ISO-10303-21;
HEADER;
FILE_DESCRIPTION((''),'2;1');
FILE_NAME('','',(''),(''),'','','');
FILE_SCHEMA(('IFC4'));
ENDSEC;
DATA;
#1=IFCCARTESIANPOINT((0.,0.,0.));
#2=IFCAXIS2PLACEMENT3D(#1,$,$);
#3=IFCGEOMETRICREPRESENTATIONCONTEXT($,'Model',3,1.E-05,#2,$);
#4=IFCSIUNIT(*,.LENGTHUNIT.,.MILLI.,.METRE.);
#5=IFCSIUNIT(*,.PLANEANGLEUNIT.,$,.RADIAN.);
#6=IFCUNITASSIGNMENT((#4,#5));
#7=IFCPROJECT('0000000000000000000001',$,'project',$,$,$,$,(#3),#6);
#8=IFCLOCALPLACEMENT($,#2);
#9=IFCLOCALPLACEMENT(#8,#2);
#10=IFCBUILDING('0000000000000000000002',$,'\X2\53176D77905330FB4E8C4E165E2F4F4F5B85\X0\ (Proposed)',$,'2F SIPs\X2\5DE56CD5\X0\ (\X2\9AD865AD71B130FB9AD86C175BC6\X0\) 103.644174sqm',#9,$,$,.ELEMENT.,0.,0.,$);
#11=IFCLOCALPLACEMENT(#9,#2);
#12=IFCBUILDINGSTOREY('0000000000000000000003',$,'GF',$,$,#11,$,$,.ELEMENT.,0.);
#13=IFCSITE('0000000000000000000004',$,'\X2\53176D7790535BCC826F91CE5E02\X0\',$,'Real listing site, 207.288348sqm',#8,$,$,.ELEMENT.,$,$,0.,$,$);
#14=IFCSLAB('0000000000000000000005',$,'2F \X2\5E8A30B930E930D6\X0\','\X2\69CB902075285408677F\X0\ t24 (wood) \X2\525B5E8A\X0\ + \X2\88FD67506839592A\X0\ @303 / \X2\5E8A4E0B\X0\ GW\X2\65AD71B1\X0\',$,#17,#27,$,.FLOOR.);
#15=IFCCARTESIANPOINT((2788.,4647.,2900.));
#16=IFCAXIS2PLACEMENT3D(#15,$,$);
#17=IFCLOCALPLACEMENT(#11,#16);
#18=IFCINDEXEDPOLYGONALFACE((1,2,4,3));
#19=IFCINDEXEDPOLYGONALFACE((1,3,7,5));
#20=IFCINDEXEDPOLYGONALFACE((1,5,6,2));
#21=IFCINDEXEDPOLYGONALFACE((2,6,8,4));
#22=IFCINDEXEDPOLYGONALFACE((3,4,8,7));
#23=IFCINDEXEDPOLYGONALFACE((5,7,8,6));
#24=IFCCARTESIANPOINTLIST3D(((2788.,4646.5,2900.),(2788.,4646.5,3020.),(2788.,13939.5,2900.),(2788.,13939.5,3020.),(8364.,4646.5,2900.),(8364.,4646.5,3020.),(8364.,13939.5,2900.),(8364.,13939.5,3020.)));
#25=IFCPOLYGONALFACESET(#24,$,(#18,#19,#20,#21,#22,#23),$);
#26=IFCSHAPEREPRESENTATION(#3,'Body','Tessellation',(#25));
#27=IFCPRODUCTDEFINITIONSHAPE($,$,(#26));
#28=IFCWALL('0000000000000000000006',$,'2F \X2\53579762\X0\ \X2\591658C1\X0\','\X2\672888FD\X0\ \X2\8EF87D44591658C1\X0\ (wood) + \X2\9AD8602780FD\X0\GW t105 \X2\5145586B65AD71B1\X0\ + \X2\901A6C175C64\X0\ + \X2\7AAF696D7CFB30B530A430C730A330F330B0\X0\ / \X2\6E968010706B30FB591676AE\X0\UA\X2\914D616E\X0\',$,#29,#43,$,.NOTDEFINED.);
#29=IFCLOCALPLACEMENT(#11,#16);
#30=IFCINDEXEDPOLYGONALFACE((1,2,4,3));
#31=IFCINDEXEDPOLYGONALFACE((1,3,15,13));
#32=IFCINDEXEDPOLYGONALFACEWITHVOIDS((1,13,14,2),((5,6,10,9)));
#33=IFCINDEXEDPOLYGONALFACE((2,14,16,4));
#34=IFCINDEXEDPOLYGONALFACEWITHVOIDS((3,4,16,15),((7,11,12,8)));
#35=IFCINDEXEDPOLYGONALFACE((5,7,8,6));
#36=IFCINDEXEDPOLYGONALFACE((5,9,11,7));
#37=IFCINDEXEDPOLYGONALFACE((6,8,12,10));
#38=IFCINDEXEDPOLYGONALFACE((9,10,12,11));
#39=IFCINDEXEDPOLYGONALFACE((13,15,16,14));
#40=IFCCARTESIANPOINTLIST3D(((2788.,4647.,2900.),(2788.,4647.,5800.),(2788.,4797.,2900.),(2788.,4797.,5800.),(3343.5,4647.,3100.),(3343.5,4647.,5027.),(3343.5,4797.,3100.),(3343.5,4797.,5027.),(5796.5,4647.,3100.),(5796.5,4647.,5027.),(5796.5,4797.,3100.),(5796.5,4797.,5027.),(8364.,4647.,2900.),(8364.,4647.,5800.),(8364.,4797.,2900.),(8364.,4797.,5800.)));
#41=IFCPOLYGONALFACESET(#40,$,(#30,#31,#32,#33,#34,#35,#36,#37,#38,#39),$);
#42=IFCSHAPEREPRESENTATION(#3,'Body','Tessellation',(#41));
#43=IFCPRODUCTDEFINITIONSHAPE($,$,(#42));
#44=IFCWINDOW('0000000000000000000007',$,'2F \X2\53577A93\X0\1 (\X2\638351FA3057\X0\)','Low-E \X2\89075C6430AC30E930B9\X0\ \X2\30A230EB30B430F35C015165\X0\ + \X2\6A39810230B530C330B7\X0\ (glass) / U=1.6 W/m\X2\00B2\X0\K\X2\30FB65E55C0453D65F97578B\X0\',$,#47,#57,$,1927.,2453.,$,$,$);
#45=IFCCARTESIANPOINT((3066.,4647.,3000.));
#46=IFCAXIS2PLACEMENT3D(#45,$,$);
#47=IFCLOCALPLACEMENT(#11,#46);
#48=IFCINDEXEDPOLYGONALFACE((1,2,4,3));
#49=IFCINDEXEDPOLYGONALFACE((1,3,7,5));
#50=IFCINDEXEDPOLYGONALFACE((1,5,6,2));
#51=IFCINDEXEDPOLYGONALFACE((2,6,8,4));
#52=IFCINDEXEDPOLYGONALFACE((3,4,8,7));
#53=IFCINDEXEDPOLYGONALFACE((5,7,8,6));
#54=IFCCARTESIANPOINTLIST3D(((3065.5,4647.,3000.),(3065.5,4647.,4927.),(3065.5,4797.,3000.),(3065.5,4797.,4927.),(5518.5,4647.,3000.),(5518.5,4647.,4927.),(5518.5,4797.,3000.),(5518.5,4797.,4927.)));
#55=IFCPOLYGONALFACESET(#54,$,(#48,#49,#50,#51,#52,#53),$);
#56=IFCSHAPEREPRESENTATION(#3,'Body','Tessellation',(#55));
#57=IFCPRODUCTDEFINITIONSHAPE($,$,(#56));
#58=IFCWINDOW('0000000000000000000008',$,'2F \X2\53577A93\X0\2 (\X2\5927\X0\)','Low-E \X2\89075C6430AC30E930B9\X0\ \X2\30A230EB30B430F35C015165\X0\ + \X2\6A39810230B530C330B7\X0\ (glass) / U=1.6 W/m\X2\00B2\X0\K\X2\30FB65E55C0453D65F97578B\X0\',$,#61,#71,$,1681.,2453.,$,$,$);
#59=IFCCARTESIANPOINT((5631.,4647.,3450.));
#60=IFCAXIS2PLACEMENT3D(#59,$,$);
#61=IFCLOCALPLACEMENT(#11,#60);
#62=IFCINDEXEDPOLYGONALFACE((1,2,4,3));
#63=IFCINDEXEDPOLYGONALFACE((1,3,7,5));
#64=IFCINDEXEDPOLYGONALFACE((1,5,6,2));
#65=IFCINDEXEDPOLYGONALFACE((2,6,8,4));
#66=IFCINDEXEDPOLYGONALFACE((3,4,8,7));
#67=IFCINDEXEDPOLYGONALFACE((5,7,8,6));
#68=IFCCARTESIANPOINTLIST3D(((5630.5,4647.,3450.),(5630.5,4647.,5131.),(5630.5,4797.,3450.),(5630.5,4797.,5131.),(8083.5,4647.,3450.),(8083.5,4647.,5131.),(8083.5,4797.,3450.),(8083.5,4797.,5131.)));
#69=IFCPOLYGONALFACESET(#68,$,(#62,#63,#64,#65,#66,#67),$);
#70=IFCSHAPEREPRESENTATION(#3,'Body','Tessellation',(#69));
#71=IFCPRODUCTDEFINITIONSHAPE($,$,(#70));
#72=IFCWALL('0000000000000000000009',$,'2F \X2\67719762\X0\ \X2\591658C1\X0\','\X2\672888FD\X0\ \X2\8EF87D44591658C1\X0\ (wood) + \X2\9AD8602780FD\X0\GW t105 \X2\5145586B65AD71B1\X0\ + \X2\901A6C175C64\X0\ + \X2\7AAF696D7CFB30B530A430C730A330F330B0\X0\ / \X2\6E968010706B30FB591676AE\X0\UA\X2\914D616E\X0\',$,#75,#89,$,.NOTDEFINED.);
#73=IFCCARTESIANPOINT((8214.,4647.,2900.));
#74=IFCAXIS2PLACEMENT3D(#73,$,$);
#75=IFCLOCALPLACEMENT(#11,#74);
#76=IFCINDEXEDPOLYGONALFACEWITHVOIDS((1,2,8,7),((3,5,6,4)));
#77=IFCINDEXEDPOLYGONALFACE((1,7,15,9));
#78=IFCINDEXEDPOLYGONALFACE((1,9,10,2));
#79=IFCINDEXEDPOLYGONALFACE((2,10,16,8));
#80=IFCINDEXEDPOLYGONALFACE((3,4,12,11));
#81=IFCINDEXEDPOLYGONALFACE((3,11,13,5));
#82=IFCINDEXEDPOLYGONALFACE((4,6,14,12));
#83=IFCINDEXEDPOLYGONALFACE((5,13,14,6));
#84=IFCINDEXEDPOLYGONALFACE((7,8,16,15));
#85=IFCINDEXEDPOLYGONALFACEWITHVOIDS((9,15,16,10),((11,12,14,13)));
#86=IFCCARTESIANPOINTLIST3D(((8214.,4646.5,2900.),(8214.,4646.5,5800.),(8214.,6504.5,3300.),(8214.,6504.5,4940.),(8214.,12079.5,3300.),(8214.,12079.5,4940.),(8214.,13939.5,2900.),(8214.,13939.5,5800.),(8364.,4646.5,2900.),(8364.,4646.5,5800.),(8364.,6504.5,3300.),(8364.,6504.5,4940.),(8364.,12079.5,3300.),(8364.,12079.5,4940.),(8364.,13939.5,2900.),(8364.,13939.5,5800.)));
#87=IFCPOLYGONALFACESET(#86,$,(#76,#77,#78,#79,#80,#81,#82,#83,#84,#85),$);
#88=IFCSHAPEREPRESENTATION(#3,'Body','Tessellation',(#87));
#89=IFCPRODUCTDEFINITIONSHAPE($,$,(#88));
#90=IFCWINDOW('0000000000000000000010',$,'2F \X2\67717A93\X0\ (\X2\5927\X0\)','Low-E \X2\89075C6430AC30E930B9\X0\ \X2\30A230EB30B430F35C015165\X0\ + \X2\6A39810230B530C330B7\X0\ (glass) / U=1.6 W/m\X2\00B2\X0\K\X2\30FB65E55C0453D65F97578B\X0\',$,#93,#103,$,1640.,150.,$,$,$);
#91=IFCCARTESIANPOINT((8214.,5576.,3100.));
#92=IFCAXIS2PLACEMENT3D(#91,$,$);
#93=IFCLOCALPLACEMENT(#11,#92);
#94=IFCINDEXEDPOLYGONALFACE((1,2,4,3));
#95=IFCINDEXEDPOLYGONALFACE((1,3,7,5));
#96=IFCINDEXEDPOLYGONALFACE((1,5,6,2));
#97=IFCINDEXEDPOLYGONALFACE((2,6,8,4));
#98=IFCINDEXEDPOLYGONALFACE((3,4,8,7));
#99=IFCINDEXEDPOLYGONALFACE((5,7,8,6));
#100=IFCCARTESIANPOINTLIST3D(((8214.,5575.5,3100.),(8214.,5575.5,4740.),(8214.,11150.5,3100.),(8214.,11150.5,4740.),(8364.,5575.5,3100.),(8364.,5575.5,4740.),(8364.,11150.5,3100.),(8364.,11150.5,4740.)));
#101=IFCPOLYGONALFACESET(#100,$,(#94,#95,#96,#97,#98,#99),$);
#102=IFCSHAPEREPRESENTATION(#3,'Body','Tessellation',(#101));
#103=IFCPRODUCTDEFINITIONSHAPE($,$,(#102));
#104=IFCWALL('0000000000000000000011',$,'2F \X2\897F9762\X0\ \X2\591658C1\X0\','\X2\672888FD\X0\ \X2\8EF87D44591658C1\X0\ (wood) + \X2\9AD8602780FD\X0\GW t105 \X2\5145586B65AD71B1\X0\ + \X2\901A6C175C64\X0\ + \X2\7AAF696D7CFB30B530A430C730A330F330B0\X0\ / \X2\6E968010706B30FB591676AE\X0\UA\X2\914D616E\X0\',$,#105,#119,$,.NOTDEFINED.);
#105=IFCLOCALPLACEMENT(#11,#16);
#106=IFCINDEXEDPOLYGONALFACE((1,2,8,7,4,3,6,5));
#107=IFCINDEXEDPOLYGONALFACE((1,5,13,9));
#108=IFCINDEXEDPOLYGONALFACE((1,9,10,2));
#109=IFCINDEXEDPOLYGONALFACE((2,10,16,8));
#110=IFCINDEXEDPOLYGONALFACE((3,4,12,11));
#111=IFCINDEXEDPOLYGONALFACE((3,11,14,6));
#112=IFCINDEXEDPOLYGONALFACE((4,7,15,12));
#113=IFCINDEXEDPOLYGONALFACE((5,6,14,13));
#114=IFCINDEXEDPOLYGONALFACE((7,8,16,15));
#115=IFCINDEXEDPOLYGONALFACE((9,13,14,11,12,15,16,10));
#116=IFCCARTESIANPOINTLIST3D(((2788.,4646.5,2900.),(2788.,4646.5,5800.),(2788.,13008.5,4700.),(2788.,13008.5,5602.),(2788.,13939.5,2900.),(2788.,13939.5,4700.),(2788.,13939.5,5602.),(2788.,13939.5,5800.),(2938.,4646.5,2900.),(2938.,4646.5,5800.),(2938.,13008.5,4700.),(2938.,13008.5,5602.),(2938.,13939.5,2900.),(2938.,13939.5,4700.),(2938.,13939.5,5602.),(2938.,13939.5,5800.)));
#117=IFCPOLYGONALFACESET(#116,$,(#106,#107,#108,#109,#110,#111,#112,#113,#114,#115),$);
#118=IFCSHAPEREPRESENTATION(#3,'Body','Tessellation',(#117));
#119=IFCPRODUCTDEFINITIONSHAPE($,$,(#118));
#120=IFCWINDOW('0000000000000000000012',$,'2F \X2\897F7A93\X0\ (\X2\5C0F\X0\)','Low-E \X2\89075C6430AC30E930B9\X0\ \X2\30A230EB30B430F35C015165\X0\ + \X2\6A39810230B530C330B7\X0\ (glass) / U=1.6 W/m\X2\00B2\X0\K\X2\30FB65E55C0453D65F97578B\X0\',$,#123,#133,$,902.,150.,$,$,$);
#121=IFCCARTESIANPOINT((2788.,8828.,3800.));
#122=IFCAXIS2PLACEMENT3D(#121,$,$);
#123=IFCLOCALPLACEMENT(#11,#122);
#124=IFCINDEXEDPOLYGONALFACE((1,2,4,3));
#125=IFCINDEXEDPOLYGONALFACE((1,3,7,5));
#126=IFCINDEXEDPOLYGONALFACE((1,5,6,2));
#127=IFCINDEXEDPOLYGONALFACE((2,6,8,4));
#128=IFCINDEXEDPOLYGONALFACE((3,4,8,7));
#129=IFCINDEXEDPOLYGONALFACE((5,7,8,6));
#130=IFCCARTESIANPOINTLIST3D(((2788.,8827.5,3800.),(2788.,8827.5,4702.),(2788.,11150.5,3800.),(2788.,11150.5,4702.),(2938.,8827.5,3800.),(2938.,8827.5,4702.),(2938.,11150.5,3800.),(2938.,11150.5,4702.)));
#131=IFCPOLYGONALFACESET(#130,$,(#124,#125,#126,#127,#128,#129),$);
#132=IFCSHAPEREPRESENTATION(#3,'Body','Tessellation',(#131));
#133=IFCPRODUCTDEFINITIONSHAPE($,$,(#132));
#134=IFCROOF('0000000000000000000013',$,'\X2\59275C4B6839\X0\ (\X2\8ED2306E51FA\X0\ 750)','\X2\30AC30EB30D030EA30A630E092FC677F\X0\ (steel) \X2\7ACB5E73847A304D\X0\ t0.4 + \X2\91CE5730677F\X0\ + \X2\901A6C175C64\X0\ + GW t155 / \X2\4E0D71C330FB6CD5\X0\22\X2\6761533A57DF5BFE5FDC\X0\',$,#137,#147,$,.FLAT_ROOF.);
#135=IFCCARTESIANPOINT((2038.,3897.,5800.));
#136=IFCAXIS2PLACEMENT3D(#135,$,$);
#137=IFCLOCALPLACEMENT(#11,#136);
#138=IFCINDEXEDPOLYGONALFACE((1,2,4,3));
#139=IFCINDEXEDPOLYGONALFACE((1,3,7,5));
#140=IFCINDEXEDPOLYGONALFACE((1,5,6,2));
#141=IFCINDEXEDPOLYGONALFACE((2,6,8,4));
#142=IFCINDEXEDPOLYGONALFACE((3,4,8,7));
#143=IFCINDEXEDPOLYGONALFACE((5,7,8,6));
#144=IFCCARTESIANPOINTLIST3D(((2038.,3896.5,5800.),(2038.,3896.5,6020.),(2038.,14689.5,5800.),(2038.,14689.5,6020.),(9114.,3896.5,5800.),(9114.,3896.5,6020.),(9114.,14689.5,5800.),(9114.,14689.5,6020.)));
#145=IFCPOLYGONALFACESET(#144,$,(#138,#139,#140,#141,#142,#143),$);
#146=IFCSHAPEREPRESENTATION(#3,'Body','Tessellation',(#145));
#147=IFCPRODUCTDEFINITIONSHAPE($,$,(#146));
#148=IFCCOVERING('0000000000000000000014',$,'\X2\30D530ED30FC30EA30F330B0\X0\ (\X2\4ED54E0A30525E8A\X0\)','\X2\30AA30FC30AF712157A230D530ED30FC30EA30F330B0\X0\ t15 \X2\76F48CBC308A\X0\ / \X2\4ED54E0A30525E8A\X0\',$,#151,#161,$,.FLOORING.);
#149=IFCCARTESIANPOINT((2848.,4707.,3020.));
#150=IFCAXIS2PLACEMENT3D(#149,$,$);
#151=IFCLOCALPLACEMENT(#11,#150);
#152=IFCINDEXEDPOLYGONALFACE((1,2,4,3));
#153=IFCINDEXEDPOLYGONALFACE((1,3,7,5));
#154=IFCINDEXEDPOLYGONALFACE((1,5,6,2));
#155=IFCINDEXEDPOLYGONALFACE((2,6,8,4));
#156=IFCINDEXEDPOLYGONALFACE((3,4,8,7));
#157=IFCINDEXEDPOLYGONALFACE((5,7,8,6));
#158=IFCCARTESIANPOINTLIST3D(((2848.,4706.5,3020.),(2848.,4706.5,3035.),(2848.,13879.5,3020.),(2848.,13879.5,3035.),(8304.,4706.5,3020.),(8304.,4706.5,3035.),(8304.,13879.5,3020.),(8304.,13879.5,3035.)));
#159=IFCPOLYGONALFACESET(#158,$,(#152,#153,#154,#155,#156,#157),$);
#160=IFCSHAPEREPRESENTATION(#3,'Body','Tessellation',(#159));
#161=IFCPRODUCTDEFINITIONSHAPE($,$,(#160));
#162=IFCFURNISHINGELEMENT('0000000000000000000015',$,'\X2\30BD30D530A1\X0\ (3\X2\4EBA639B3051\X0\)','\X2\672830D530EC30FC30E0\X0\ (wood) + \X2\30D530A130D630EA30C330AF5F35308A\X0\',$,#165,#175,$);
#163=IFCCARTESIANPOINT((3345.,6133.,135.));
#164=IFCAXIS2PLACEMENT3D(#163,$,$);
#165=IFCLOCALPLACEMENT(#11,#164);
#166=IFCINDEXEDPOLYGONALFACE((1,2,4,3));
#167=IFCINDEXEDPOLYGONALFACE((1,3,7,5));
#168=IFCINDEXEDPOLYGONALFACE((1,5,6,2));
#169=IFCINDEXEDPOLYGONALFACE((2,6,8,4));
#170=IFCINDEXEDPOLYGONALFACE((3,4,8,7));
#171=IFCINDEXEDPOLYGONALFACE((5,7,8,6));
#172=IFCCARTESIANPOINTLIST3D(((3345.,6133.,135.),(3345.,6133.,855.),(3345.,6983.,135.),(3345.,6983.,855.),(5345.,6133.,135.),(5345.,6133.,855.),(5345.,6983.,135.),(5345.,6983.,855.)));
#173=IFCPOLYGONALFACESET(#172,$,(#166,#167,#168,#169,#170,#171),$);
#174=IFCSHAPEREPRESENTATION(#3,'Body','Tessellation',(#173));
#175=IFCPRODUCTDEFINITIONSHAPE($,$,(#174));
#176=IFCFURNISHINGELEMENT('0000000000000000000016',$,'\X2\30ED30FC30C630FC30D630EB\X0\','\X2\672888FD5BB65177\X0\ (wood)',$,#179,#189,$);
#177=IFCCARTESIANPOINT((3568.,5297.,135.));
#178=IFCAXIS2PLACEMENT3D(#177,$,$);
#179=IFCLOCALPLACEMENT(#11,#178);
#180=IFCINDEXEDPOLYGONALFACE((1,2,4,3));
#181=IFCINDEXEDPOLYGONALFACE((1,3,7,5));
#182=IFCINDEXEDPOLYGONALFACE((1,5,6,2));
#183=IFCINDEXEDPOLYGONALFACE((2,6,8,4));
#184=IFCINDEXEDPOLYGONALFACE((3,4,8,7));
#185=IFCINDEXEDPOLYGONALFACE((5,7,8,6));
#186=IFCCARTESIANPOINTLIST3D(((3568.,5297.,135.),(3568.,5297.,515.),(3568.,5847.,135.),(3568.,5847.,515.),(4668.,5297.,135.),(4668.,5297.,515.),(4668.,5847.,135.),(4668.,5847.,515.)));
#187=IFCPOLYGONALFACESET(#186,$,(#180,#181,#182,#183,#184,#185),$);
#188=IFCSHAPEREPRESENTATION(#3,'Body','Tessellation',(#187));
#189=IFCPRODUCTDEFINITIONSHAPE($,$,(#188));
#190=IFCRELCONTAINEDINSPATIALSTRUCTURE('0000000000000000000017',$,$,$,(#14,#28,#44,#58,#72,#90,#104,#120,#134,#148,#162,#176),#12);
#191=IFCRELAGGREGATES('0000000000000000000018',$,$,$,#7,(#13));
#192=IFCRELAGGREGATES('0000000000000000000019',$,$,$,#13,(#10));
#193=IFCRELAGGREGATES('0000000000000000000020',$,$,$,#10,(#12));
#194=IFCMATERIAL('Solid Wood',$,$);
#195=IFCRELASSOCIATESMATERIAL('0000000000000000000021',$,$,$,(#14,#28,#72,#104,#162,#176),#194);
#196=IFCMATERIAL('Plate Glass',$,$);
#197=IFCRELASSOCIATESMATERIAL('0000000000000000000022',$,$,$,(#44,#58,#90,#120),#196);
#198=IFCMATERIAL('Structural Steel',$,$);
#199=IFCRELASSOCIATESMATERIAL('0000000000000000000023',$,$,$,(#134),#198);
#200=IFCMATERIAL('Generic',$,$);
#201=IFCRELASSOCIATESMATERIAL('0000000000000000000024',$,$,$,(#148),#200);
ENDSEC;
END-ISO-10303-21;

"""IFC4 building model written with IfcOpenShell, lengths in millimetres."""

from ifc_helpers import new_model, si_unit, frame, frame_2d, origin, place, context, project, spatial, rectangle, extrude, material, element, fill, save


model = new_model("IFC4")

# Units and contexts
model_context = context("Model", 3, precision=1e-05, world=origin())
ifc_project = project(units=[si_unit("LENGTHUNIT", "METRE", prefix="MILLI"), si_unit("PLANEANGLEUNIT", "RADIAN")], contexts=[model_context])

# Site, building, storey
site_placement = place(None, origin())
site = spatial("IfcSite", under=ifc_project, at=site_placement, Name="北海道富良野市", ObjectType="Real listing site, 207.288348sqm", CompositionType="ELEMENT", RefElevation=0.0)
building_placement = place(site_placement, origin())
building = spatial("IfcBuilding", under=site, at=building_placement, Name="北海道・二世帯住宅 (Proposed)", ObjectType="2F SIPs工法 (高断熱・高気密) 103.644174sqm", CompositionType="ELEMENT", ElevationOfRefHeight=0.0, ElevationOfTerrain=0.0)
storey_placement = place(building_placement, origin())
storey = spatial("IfcBuildingStorey", under=building, at=storey_placement, Name="GF", CompositionType="ELEMENT", Elevation=0.0)

# Slab
ifc_material_1 = material(Name="Solid Wood")
slab_placement = place(storey_placement, frame((2788.0, 4647.0, 2900.0)))
element("IfcSlab", 1, at=slab_placement, inside=storey, material=ifc_material_1, Name="2F 床スラブ", Description="構造用合板 t24 (wood) 剛床 + 製材根太 @303 / 床下 GW断熱", PredefinedType="FLOOR", context=model_context, shape_type="SweptSolid", body=[
    extrude(rectangle(XDim=5576.0, YDim=9293.0, at=frame_2d((2788.0, 4646.0))), frame((2788.0, 4647.0, 2900.0)), (0.0, 0.0, 1.0), 120.0),
])

# Wall, openings, windows
wall_1_placement = place(storey_placement, frame((2788.0, 4647.0, 2900.0)))
wall_1 = element("IfcWall", 2, at=wall_1_placement, inside=storey, material=ifc_material_1, Name="2F 南面 外壁", Description="木製 軸組外壁 (wood) + 高性能GW t105 充填断熱 + 通気層 + 窯業系サイディング / 準耐火・外皮UA配慮", PredefinedType="NOTDEFINED", context=model_context, shape_type="SweptSolid", body=[
    extrude(rectangle(XDim=5576.0, YDim=150.0, at=frame_2d((2788.0, 75.0))), frame((2788.0, 4647.0, 2900.0)), (0.0, 0.0, 1.0), 2900.0),
])
opening_1_placement = place(storey_placement, frame((3066.0, 4647.0, 3000.0)))
opening_1 = element("IfcOpeningElement", 3, at=opening_1_placement, cuts=wall_1, PredefinedType="NOTDEFINED", context=model_context, shape_type="SweptSolid", body=[
    extrude(rectangle(XDim=2453.0, YDim=150.0, at=frame_2d((1226.0, 75.0))), frame((3066.0, 4647.0, 3000.0)), (0.0, 0.0, 1.0), 1927.0),
])
opening_2_placement = place(storey_placement, frame((5631.0, 4647.0, 3450.0)))
opening_2 = element("IfcOpeningElement", 4, at=opening_2_placement, cuts=wall_1, PredefinedType="NOTDEFINED", context=model_context, shape_type="SweptSolid", body=[
    extrude(rectangle(XDim=2453.0, YDim=150.0, at=frame_2d((1226.0, 75.0))), frame((5631.0, 4647.0, 3450.0)), (0.0, 0.0, 1.0), 1681.0),
])
ifc_material_2 = material(Name="Plate Glass")
window_1_placement = place(storey_placement, frame((3066.0, 4647.0, 3000.0)))
window_1 = element("IfcWindow", 5, at=window_1_placement, inside=storey, material=ifc_material_2, Name="2F 南窓1 (掃出し)", Description="Low-E 複層ガラス アルゴン封入 + 樹脂サッシ (glass) / U=1.6 W/m²K・日射取得型", OverallHeight=1927.0, OverallWidth=2453.0, context=model_context, shape_type="SweptSolid", body=[
    extrude(rectangle(XDim=2453.0, YDim=150.0, at=frame_2d((1226.0, 75.0))), frame((3066.0, 4647.0, 3000.0)), (0.0, 0.0, 1.0), 1927.0),
])
fill(opening_1, window_1)
window_2_placement = place(storey_placement, frame((5631.0, 4647.0, 3450.0)))
window_2 = element("IfcWindow", 6, at=window_2_placement, inside=storey, material=ifc_material_2, Name="2F 南窓2 (大)", Description="Low-E 複層ガラス アルゴン封入 + 樹脂サッシ (glass) / U=1.6 W/m²K・日射取得型", OverallHeight=1681.0, OverallWidth=2453.0, context=model_context, shape_type="SweptSolid", body=[
    extrude(rectangle(XDim=2453.0, YDim=150.0, at=frame_2d((1226.0, 75.0))), frame((5631.0, 4647.0, 3450.0)), (0.0, 0.0, 1.0), 1681.0),
])
fill(opening_2, window_2)

# Walls, openings, windows
wall_2_placement = place(storey_placement, frame((8214.0, 4647.0, 2900.0)))
wall_2 = element("IfcWall", 7, at=wall_2_placement, inside=storey, material=ifc_material_1, Name="2F 東面 外壁", Description="木製 軸組外壁 (wood) + 高性能GW t105 充填断熱 + 通気層 + 窯業系サイディング / 準耐火・外皮UA配慮", PredefinedType="NOTDEFINED", context=model_context, shape_type="SweptSolid", body=[
    extrude(rectangle(XDim=150.0, YDim=9293.0, at=frame_2d((75.0, 4646.0))), frame((8214.0, 4647.0, 2900.0)), (0.0, 0.0, 1.0), 2900.0),
])
opening_3_placement = place(storey_placement, frame((8214.0, 5576.0, 3100.0)))
opening_3 = element("IfcOpeningElement", 8, at=opening_3_placement, cuts=wall_2, PredefinedType="NOTDEFINED", context=model_context, shape_type="SweptSolid", body=[
    extrude(rectangle(XDim=150.0, YDim=5575.0, at=frame_2d((75.0, 2787.0))), frame((8214.0, 5576.0, 3100.0)), (0.0, 0.0, 1.0), 1640.0),
])
window_3_placement = place(storey_placement, frame((8214.0, 5576.0, 3100.0)))
window_3 = element("IfcWindow", 9, at=window_3_placement, inside=storey, material=ifc_material_2, Name="2F 東窓 (大)", Description="Low-E 複層ガラス アルゴン封入 + 樹脂サッシ (glass) / U=1.6 W/m²K・日射取得型", OverallHeight=1640.0, OverallWidth=150.0, context=model_context, shape_type="SweptSolid", body=[
    extrude(rectangle(XDim=150.0, YDim=5575.0, at=frame_2d((75.0, 2787.0))), frame((8214.0, 5576.0, 3100.0)), (0.0, 0.0, 1.0), 1640.0),
])
fill(opening_3, window_3)
wall_3_placement = place(storey_placement, frame((2788.0, 4647.0, 2900.0)))
wall_3 = element("IfcWall", 10, at=wall_3_placement, inside=storey, material=ifc_material_1, Name="2F 西面 外壁", Description="木製 軸組外壁 (wood) + 高性能GW t105 充填断熱 + 通気層 + 窯業系サイディング / 準耐火・外皮UA配慮", PredefinedType="NOTDEFINED", context=model_context, shape_type="SweptSolid", body=[
    extrude(rectangle(XDim=150.0, YDim=9293.0, at=frame_2d((75.0, 4646.0))), frame((2788.0, 4647.0, 2900.0)), (0.0, 0.0, 1.0), 2900.0),
])
opening_4_placement = place(storey_placement, frame((2788.0, 8828.0, 3800.0)))
opening_4 = element("IfcOpeningElement", 11, at=opening_4_placement, cuts=wall_3, PredefinedType="NOTDEFINED", context=model_context, shape_type="SweptSolid", body=[
    extrude(rectangle(XDim=150.0, YDim=2323.0, at=frame_2d((75.0, 1161.0))), frame((2788.0, 8828.0, 3800.0)), (0.0, 0.0, 1.0), 902.0),
])
window_4_placement = place(storey_placement, frame((2788.0, 8828.0, 3800.0)))
window_4 = element("IfcWindow", 12, at=window_4_placement, inside=storey, material=ifc_material_2, Name="2F 西窓 (小)", Description="Low-E 複層ガラス アルゴン封入 + 樹脂サッシ (glass) / U=1.6 W/m²K・日射取得型", OverallHeight=902.0, OverallWidth=150.0, context=model_context, shape_type="SweptSolid", body=[
    extrude(rectangle(XDim=150.0, YDim=2323.0, at=frame_2d((75.0, 1161.0))), frame((2788.0, 8828.0, 3800.0)), (0.0, 0.0, 1.0), 902.0),
])
fill(opening_4, window_4)

# Roof
ifc_material_3 = material(Name="Structural Steel")
roof_placement = place(storey_placement, frame((2038.0, 3897.0, 5800.0)))
element("IfcRoof", 13, at=roof_placement, inside=storey, material=ifc_material_3, Name="大屋根 (軒の出 750)", Description="ガルバリウム鋼板 (steel) 立平葺き t0.4 + 野地板 + 通気層 + GW t155 / 不燃・法22条区域対応", PredefinedType="FLAT_ROOF", context=model_context, shape_type="SweptSolid", body=[
    extrude(rectangle(XDim=7076.0, YDim=10793.0, at=frame_2d((3538.0, 5396.0))), frame((2038.0, 3897.0, 5800.0)), (0.0, 0.0, 1.0), 220.0),
])

# Covering
ifc_material_4 = material(Name="Generic")
covering_placement = place(storey_placement, frame((2848.0, 4707.0, 3020.0)))
element("IfcCovering", 14, at=covering_placement, inside=storey, material=ifc_material_4, Name="フローリング (仕上げ床)", Description="オーク無垢フローリング t15 直貼り / 仕上げ床", PredefinedType="FLOORING", context=model_context, shape_type="SweptSolid", body=[
    extrude(rectangle(XDim=5456.0, YDim=9173.0, at=frame_2d((2728.0, 4586.0))), frame((2848.0, 4707.0, 3020.0)), (0.0, 0.0, 1.0), 15.0),
])

# Furnishing elements
furnishing_1_placement = place(storey_placement, frame((3345.0, 6133.0, 135.0)))
element("IfcFurnishingElement", 15, at=furnishing_1_placement, inside=storey, material=ifc_material_1, Name="ソファ (3人掛け)", Description="木フレーム (wood) + ファブリック張り", context=model_context, shape_type="SweptSolid", body=[
    extrude(rectangle(XDim=2000.0, YDim=850.0, at=frame_2d((1000.0, 425.0))), frame((3345.0, 6133.0, 135.0)), (0.0, 0.0, 1.0), 720.0),
])
furnishing_2_placement = place(storey_placement, frame((3568.0, 5297.0, 135.0)))
element("IfcFurnishingElement", 16, at=furnishing_2_placement, inside=storey, material=ifc_material_1, Name="ローテーブル", Description="木製家具 (wood)", context=model_context, shape_type="SweptSolid", body=[
    extrude(rectangle(XDim=1100.0, YDim=550.0, at=frame_2d((550.0, 275.0))), frame((3568.0, 5297.0, 135.0)), (0.0, 0.0, 1.0), 380.0),
])

save(model, "model.ifc")
